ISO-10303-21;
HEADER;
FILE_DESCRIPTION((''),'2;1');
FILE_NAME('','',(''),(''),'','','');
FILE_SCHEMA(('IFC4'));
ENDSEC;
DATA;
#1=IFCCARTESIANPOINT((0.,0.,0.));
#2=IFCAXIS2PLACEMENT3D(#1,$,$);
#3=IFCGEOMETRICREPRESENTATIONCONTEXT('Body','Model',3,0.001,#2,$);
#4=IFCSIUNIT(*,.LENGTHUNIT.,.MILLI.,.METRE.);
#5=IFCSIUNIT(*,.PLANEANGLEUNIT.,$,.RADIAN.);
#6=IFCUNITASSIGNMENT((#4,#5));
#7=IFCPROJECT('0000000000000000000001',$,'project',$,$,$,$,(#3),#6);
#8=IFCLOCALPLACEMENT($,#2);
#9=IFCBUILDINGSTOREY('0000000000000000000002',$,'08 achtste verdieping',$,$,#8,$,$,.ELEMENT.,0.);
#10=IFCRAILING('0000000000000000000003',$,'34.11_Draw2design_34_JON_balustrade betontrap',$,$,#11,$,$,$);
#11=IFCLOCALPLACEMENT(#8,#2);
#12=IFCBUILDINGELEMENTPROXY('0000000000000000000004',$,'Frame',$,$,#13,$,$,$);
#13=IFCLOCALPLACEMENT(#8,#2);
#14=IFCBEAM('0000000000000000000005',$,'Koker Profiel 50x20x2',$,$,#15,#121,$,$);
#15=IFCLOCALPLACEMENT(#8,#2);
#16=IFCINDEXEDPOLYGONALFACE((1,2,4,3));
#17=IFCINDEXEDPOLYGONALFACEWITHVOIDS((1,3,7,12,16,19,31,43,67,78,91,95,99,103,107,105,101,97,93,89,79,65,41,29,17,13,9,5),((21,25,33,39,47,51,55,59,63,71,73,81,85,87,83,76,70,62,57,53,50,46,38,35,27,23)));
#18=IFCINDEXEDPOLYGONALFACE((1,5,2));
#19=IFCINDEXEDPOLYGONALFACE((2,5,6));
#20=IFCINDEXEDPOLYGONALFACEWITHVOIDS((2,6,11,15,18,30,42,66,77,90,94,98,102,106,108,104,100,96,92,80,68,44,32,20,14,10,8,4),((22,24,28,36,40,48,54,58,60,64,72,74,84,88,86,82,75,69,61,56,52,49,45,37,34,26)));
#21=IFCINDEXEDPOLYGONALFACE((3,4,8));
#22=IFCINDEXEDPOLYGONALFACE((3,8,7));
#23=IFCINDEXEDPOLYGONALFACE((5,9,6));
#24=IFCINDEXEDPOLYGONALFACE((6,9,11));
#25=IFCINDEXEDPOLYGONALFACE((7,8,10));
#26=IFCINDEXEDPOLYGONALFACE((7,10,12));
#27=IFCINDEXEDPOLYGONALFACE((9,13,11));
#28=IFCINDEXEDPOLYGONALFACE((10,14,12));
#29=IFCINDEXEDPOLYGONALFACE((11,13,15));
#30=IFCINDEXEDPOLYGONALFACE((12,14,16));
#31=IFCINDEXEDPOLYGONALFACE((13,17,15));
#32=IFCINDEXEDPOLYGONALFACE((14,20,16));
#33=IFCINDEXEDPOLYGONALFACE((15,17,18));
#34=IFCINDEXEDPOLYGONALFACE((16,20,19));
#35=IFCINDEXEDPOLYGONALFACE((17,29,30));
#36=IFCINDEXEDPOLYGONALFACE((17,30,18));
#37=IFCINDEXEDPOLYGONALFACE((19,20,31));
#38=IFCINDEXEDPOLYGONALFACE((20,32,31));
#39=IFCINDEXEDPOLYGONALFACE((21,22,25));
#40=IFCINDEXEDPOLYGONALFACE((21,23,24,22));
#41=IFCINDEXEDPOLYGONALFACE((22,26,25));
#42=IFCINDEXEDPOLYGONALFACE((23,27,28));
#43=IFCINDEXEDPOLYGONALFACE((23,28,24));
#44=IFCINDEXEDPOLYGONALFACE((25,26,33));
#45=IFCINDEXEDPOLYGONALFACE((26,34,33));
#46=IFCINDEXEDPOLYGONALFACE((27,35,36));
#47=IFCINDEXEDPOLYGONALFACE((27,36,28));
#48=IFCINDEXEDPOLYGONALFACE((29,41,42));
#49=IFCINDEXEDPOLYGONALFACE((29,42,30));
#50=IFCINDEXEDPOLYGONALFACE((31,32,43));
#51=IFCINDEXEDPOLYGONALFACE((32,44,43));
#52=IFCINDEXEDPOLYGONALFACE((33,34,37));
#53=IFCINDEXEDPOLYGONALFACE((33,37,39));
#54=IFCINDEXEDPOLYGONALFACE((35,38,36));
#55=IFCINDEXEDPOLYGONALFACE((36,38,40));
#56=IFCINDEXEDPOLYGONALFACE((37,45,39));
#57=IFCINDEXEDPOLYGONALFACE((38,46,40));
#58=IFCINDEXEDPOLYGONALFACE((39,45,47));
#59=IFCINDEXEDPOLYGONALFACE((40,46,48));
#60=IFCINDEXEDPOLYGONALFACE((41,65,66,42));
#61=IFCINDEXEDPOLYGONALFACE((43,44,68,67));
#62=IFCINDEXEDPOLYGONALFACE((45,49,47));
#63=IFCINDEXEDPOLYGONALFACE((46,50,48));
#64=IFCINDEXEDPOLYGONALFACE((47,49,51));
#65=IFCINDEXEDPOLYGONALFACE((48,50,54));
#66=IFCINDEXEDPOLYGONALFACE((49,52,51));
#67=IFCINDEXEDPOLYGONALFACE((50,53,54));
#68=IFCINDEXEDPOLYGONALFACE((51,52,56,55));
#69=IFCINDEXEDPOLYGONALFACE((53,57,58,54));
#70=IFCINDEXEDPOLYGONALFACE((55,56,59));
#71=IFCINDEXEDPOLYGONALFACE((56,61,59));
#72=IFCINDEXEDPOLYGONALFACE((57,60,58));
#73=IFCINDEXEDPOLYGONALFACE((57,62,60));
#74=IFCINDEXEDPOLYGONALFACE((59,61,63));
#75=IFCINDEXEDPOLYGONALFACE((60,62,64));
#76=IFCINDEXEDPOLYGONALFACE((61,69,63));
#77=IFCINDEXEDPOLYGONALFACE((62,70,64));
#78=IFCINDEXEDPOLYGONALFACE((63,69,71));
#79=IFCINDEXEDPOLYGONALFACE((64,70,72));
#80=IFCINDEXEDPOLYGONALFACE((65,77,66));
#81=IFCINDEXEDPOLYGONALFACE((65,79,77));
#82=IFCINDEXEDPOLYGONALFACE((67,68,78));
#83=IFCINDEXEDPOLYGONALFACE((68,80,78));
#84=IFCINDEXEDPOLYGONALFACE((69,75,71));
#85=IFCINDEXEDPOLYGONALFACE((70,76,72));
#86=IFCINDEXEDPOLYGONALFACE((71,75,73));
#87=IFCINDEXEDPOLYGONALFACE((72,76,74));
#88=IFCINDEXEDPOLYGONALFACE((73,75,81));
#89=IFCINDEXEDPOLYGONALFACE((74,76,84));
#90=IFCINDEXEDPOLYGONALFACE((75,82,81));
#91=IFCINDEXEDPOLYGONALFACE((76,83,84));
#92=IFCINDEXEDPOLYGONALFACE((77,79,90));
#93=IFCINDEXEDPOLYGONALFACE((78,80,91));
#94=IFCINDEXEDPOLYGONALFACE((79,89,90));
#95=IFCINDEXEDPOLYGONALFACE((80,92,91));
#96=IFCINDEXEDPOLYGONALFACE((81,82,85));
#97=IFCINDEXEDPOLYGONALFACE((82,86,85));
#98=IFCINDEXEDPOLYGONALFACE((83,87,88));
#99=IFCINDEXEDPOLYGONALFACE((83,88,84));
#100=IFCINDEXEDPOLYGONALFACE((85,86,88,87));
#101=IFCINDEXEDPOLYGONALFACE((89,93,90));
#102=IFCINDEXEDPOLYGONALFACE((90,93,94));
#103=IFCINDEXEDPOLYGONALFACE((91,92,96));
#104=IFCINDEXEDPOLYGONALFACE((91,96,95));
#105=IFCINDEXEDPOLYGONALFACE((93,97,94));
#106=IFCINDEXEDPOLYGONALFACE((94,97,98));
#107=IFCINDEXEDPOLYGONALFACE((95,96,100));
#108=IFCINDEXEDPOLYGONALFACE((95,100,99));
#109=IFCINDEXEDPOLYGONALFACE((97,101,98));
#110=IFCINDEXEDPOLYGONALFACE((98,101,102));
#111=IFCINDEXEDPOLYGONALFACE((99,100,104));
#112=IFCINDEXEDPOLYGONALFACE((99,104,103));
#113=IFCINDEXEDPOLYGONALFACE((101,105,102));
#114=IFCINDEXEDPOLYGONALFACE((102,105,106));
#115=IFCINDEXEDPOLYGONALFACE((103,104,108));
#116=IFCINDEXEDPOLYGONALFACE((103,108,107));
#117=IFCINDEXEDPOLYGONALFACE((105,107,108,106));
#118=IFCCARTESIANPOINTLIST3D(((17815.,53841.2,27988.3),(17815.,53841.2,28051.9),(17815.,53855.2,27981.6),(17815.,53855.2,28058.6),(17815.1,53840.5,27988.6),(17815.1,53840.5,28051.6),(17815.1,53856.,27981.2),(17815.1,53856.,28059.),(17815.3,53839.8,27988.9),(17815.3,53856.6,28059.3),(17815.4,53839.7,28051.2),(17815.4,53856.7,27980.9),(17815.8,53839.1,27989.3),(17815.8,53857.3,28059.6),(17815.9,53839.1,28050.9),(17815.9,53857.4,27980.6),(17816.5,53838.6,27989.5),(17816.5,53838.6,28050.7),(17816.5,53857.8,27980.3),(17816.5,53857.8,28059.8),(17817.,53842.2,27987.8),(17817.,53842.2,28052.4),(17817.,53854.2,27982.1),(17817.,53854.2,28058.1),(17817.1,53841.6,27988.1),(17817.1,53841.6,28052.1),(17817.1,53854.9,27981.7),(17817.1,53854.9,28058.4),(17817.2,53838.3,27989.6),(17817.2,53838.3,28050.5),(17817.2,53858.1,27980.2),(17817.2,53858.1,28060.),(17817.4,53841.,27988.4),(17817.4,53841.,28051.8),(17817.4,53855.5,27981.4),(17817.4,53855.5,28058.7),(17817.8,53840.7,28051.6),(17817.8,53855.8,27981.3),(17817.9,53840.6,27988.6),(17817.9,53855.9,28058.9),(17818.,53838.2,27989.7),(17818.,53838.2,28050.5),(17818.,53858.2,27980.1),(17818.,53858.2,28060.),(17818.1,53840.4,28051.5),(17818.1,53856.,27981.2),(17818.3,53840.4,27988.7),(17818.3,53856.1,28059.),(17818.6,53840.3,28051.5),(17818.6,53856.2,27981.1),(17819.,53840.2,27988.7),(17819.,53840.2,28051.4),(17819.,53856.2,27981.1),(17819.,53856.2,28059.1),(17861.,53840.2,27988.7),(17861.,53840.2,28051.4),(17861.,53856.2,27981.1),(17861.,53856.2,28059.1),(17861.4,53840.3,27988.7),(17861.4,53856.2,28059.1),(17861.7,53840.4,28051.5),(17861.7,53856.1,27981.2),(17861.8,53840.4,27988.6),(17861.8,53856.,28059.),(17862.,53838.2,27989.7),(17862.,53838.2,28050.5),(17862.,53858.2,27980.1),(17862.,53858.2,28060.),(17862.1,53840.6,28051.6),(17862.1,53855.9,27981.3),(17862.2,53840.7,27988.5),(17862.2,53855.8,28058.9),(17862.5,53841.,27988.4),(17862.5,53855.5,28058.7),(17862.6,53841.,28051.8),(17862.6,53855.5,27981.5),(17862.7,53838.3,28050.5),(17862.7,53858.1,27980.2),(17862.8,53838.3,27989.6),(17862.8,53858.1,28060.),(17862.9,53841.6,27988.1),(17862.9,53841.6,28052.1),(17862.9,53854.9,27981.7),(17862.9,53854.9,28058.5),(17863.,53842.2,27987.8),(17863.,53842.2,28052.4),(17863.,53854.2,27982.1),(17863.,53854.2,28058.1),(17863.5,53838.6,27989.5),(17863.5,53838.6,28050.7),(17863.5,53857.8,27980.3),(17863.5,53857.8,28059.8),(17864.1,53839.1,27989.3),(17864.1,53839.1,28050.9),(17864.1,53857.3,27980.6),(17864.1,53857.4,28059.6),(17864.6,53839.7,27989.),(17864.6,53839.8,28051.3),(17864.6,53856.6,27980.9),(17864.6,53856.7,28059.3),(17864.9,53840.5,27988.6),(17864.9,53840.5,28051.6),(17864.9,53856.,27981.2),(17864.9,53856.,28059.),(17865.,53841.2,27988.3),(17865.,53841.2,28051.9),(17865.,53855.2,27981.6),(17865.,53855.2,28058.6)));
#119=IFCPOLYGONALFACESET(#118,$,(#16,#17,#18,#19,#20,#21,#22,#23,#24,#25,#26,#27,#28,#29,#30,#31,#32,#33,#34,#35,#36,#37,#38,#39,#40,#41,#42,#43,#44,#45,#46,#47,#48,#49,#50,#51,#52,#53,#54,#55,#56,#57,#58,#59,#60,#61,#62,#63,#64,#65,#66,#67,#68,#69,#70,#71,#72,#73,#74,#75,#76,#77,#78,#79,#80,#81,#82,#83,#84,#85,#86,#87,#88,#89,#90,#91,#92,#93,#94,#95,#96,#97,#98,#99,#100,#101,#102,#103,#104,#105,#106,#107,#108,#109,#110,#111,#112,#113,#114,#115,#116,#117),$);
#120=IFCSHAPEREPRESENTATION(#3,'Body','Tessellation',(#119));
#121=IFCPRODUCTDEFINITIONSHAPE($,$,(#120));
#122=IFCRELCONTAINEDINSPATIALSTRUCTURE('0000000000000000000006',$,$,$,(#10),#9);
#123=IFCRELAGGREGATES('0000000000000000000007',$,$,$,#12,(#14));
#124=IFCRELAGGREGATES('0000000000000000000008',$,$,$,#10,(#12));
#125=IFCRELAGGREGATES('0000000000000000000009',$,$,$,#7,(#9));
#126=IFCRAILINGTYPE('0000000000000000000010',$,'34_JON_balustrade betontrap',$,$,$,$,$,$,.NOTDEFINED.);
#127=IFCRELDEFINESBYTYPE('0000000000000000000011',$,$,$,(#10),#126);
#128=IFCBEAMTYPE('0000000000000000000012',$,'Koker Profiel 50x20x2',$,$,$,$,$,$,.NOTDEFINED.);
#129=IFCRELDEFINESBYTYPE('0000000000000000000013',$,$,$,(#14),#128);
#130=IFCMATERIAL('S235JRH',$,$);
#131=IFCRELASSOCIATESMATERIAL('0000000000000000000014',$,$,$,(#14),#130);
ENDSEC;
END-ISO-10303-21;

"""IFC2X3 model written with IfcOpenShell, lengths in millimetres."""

from ifc_helpers import new_model, si_unit, frame, origin, origin_2d, place, context, project, spatial, hollow_rectangle, extrude, clip, halfspace, source, transform, mapped, material, type_object, element, aggregate, save


model = new_model("IFC2X3")

# Units and contexts
model_context = context("Model", 3, precision=0.001, world=origin(), identifier="Body")
ifc_project = project(units=[si_unit("LENGTHUNIT", "METRE", prefix="MILLI"), si_unit("PLANEANGLEUNIT", "RADIAN")], contexts=[model_context])

# Storey
storey_placement = place(None, origin())
storey = spatial("IfcBuildingStorey", under=ifc_project, at=storey_placement, Name="08 achtste verdieping", CompositionType="ELEMENT", Elevation=0.0)

# Railing, building element proxy
railing_type = type_object("IfcRailingType", Name="34_JON_balustrade betontrap")
railing_1_placement = place(storey_placement, frame((-2939.5, 7875.7, -20904.2), z_axis=(0.0, 0.0, 1.0), x_axis=(1.0, 0.0, 0.0)))
railing_1 = element("IfcRailing", 1, at=railing_1_placement, inside=storey, type_object=railing_type, Name="34.11_Draw2design_34_JON_balustrade betontrap")
ifc_material_1 = material(Name="S235JRH")
proxy_1_placement = place(railing_1_placement, origin())
proxy_1 = element("IfcBuildingElementProxy", 2, at=proxy_1_placement, Name="Frame")
beam_type_1 = type_object("IfcBeamType", Name="Koker Profiel 50x20x2")

# Beam
shared_shape_1 = source(origin(), model_context, "Body", "Clipping", [
    clip(clip(extrude(hollow_rectangle(XDim=20.0, YDim=50.0, WallThickness=2.0, InnerFilletRadius=2.0, OuterFilletRadius=3.0, at=origin_2d()), origin(), (0.0, 0.0, -1.0), 79.9), halfspace(frame((-10.0, 25.0, -9.6), z_axis=(-0.430948, 0.0, 0.902377), x_axis=(0.902377, 0.0, 0.430948)), False)), halfspace(frame((-10.0, -25.0, -70.3), z_axis=(-0.430948, 0.0, -0.902377), x_axis=(-0.902377, 0.0, 0.430948)), False)),
])
beam_1_placement = place(proxy_1_placement, frame((20779.5, 45972.5, 48964.2), z_axis=(0.0, 0.0, 1.0), x_axis=(0.0, 1.0, 0.0)))
beam_1 = element("IfcBeam", 3, at=beam_1_placement, type_object=beam_type_1, material=ifc_material_1, Name="Koker Profiel 50x20x2", context=model_context, shape_type="MappedRepresentation", body=[
    mapped(shared_shape_1, transform((0.0, 0.0, 0.0), scale=1.0)),
])
aggregate(proxy_1, [beam_1])

aggregate(railing_1, [proxy_1])

save(model, "model.ifc")
